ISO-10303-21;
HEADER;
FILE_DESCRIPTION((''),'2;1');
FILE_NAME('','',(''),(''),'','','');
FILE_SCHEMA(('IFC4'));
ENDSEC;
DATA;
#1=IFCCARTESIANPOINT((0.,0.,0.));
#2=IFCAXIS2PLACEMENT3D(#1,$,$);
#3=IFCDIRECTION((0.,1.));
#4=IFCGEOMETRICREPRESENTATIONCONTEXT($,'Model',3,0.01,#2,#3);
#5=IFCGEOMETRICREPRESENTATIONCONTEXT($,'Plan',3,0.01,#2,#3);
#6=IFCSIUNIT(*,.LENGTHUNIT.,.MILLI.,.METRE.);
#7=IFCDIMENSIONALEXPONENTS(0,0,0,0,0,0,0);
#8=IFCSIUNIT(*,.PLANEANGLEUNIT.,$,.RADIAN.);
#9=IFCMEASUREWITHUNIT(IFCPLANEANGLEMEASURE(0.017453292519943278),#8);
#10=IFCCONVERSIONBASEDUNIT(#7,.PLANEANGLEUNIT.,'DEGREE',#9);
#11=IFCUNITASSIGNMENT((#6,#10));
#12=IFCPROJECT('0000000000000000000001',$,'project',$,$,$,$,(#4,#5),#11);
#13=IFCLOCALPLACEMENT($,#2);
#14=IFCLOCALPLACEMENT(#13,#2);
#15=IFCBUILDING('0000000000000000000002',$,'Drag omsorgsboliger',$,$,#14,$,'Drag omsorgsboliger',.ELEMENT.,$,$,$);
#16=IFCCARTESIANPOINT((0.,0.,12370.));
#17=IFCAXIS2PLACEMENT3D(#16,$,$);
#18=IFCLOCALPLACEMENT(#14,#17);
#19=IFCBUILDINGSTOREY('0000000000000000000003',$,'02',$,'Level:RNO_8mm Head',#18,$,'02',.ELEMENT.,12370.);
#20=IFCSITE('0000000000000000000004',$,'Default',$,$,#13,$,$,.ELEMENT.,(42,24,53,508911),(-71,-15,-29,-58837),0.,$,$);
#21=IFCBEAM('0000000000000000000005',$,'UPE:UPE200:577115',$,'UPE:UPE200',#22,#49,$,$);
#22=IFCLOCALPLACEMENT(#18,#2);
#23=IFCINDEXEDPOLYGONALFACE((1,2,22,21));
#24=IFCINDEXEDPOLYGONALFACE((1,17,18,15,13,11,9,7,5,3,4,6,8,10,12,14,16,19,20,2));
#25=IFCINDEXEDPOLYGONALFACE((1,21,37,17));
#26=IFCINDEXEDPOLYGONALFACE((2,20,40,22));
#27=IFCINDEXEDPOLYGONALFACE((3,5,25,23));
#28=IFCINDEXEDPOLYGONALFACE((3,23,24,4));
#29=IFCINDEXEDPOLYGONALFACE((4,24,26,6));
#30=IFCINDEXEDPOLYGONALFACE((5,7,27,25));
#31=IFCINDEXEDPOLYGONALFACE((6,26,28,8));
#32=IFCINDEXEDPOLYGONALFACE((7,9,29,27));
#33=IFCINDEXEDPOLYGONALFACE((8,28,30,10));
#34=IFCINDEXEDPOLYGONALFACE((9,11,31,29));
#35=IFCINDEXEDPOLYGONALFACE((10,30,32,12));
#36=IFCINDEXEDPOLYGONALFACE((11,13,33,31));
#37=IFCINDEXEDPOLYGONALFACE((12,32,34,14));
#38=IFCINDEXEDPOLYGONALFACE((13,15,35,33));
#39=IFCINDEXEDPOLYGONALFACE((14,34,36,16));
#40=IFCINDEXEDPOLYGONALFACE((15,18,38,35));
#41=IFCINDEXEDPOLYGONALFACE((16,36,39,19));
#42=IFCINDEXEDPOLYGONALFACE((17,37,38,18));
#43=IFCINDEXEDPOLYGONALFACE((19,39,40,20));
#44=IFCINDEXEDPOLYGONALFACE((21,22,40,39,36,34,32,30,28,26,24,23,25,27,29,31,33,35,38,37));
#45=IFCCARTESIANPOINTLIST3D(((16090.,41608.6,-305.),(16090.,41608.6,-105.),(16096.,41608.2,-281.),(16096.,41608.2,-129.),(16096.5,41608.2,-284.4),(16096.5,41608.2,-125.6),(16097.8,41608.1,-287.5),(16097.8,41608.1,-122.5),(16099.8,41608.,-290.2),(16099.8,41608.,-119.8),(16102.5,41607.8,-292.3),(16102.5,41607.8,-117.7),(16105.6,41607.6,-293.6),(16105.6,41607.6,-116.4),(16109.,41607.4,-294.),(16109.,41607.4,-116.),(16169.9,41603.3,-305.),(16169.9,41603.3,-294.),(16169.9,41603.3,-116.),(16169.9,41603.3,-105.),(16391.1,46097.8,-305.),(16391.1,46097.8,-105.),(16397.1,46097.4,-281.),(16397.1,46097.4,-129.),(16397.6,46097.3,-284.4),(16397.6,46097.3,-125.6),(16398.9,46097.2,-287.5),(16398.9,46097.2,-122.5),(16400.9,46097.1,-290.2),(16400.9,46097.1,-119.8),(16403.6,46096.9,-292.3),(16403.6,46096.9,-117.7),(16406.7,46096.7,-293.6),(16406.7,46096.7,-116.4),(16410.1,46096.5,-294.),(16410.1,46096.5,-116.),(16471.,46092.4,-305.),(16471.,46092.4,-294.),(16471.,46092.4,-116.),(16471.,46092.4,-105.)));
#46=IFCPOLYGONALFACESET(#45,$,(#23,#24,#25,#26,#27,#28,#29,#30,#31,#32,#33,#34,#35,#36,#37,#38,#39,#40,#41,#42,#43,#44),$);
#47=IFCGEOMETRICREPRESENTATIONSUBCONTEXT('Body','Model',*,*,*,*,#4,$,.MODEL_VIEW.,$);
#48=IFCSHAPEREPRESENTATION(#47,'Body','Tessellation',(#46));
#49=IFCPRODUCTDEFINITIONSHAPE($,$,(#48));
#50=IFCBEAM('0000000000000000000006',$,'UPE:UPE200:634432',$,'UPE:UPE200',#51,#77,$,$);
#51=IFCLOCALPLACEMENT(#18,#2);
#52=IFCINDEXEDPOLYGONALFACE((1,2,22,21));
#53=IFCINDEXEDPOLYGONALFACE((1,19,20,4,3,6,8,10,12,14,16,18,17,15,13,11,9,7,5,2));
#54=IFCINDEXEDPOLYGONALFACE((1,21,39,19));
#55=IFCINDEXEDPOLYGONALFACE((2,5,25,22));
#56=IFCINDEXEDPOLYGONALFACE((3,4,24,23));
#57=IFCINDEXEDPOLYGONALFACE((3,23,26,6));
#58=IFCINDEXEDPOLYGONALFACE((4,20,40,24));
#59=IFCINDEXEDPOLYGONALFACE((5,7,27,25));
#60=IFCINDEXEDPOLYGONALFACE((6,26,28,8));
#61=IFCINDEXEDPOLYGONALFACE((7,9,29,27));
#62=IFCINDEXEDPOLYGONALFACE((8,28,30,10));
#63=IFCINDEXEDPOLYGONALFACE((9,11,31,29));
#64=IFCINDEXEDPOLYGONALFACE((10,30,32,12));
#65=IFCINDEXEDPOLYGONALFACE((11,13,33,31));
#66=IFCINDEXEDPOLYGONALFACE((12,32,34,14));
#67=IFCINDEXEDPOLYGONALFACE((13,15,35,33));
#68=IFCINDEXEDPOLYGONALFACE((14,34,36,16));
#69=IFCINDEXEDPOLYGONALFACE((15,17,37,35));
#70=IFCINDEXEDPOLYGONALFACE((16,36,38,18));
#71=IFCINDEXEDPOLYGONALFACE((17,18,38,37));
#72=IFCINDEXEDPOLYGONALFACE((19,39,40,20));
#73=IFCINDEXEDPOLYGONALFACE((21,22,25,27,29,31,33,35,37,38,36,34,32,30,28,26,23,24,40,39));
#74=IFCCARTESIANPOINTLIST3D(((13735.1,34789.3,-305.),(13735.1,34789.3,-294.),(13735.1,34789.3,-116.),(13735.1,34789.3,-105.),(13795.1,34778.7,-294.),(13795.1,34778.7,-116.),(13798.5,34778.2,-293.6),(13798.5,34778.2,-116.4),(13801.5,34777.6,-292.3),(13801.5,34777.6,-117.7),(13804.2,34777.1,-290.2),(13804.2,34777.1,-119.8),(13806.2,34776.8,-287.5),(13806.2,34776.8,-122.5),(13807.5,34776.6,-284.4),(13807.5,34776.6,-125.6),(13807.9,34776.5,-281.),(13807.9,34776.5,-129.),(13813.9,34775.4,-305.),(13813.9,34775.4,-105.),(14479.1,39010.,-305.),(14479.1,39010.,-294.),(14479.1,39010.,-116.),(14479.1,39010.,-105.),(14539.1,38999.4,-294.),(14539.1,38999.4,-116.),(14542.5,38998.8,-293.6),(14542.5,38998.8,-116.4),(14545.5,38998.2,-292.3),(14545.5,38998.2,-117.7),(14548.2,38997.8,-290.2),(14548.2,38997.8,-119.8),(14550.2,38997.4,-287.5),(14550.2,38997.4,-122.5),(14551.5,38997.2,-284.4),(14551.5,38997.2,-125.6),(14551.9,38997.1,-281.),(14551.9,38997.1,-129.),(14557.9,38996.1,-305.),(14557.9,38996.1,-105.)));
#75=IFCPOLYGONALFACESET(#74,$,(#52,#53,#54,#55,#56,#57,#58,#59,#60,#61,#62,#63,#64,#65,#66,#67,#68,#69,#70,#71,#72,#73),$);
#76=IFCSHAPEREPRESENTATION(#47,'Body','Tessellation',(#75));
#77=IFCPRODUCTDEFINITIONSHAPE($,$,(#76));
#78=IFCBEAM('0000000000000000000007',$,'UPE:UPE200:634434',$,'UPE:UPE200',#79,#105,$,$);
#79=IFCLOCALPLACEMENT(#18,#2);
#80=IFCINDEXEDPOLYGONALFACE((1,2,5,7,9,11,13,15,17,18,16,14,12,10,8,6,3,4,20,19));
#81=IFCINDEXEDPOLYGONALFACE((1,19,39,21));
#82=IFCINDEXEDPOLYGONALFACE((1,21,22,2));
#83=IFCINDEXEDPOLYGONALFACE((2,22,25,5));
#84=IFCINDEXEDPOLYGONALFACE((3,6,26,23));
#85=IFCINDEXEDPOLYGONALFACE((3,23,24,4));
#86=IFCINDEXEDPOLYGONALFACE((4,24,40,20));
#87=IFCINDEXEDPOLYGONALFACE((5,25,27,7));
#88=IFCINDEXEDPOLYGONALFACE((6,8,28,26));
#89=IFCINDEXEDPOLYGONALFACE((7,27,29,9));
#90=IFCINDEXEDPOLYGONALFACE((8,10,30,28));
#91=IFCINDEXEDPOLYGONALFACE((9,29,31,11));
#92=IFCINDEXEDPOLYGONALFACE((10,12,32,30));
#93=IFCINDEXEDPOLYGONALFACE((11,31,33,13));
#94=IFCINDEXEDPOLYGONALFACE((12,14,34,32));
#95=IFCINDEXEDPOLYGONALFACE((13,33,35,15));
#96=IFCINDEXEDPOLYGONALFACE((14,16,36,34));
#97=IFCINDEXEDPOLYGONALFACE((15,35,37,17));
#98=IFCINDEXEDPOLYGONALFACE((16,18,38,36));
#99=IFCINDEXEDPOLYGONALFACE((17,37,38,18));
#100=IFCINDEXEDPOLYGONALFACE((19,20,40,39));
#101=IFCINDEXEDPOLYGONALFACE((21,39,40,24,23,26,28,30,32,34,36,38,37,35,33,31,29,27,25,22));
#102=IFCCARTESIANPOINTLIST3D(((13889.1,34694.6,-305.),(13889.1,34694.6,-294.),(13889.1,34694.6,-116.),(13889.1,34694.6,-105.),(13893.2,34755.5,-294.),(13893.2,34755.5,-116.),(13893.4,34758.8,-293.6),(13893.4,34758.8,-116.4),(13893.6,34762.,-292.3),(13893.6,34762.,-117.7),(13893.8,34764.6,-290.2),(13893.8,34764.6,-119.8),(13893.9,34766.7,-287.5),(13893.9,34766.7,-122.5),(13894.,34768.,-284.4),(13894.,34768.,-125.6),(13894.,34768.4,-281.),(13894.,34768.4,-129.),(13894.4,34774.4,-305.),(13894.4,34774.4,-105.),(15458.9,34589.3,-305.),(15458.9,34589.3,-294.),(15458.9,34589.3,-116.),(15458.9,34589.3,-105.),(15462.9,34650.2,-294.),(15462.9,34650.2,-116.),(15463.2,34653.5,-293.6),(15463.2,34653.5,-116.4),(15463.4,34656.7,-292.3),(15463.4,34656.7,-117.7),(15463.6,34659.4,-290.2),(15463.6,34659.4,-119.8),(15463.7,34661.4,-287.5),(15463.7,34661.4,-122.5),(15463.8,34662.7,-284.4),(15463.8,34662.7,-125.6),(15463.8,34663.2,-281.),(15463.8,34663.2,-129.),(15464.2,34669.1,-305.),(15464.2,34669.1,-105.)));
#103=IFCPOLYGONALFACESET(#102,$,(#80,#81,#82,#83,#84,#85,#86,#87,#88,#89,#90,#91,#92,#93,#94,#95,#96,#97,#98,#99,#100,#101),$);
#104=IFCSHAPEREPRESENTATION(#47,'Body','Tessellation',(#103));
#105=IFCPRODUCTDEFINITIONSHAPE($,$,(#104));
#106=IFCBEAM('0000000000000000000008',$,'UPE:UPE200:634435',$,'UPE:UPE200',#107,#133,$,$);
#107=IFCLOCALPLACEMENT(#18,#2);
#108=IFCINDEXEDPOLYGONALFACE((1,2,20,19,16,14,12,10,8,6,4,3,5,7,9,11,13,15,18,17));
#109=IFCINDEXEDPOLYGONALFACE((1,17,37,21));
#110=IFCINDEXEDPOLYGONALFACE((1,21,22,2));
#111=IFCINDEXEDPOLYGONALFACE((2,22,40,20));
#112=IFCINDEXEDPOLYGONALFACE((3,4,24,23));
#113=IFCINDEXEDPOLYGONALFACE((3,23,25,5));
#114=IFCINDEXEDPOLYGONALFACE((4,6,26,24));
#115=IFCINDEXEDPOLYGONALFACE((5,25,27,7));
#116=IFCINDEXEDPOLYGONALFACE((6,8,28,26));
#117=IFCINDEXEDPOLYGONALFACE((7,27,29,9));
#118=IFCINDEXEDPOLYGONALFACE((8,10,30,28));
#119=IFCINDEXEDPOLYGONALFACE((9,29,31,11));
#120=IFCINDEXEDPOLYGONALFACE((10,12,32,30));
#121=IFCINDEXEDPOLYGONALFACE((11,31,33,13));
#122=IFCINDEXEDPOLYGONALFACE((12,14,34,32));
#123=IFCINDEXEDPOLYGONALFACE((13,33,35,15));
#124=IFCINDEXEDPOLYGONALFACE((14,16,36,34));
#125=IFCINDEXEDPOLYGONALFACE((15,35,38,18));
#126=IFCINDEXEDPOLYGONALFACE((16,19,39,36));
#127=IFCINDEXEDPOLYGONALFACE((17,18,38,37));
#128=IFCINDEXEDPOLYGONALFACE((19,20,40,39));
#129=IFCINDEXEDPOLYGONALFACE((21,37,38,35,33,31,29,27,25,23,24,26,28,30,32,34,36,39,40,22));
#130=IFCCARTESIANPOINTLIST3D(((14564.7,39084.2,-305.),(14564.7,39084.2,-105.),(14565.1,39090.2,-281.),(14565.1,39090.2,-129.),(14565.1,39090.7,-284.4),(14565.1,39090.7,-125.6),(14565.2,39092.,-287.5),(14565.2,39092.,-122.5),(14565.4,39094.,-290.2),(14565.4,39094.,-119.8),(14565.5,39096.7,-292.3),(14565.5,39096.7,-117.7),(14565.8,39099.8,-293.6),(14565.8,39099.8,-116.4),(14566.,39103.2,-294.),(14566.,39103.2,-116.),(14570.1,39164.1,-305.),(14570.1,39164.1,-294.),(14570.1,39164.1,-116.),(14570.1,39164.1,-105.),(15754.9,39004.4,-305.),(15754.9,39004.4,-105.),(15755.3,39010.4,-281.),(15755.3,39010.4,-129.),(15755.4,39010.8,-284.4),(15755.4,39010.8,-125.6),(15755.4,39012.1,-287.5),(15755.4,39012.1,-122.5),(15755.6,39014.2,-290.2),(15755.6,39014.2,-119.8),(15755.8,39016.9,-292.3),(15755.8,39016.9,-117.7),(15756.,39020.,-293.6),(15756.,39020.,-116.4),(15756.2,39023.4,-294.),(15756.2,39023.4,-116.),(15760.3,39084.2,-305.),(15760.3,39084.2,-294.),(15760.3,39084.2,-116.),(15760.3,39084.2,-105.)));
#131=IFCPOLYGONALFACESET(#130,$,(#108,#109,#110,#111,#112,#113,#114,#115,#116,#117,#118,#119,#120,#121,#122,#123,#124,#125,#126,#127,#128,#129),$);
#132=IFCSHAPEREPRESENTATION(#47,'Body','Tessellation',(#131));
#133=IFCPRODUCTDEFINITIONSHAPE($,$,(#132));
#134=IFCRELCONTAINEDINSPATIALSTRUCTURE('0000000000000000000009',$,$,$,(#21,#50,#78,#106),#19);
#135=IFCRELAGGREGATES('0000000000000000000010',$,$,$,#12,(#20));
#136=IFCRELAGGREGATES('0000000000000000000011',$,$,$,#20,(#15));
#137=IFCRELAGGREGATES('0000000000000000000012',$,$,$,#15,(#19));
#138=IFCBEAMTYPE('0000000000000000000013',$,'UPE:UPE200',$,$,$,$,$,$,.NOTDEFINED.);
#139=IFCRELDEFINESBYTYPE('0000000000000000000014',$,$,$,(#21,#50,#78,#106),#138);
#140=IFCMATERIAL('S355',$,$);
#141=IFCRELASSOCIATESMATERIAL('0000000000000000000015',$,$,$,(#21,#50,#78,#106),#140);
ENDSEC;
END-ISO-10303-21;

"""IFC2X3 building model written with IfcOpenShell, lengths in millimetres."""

from ifc_helpers import new_model, entity, si_unit, converted_unit, direction, frame, frame_2d, origin, place, context, subcontext, project, spatial, polyline, circle_curve, parameter, trimmed, segment, composite_curve, outline, extrude, material, type_object, element, save


model = new_model("IFC2X3")

# Units and contexts
model_context = context("Model", 3, precision=0.01, world=origin(), true_north=direction((0.0, 1.0)))
plan_context = context("Plan", 3, precision=0.01, world=origin(), true_north=direction((0.0, 1.0)))
body_context = subcontext(model_context, "Body", "Model", "MODEL_VIEW")
ifc_project = project(units=[si_unit("LENGTHUNIT", "METRE", prefix="MILLI"), converted_unit("PLANEANGLEUNIT", "DEGREE", entity("IfcPlaneAngleMeasure", 0.017453292519943278), si_unit("PLANEANGLEUNIT", "RADIAN"), dimensions=[0, 0, 0, 0, 0, 0, 0])], contexts=[model_context, plan_context])

# Site, building, storey
site_placement = place(None, origin())
site = spatial("IfcSite", under=ifc_project, at=site_placement, Name="Default", CompositionType="ELEMENT", RefLatitude=(42, 24, 53, 508911), RefLongitude=(-71, -15, -29, -58837), RefElevation=0.0)
building_placement = place(site_placement, origin())
building = spatial("IfcBuilding", under=site, at=building_placement, Name="Drag omsorgsboliger", LongName="Drag omsorgsboliger", CompositionType="ELEMENT")
storey_placement = place(building_placement, frame((0.0, 0.0, 12370.0)))
storey = spatial("IfcBuildingStorey", under=building, at=storey_placement, Name="02", ObjectType="Level:RNO_8mm Head", LongName="02", CompositionType="ELEMENT", Elevation=12370.0)

# Beams
ifc_material = material(Name="S355")
beam_type_1 = type_object("IfcBeamType", Name="UPE:UPE200", PredefinedType="NOTDEFINED")
beam_1_placement = place(storey_placement, frame((16115.8, 41610.5, -105.0), z_axis=(0.0, 0.0, 1.0), x_axis=(0.066923, 0.997758, 0.0)))
element("IfcBeam", 1, at=beam_1_placement, inside=storey, type_object=beam_type_1, material=ifc_material, Name="UPE:UPE200:577115", ObjectType="UPE:UPE200", context=body_context, shape_type="SweptSolid", body=[
    extrude(outline(composite_curve([segment(polyline([(-100.0, -43.0), (-89.0, -43.0)]), True, "CONTINUOUS"), segment(polyline([(-89.0, -43.0), (-89.0, 18.0)]), True, "CONTINUOUS"), segment(trimmed(circle_curve(frame_2d((-76.0, 18.0), x_axis=(-1.0, 0.0)), 13.0), [parameter(270.0)], [parameter(0.0)], True, "PARAMETER"), False, "CONTINUOUS"), segment(polyline([(-76.0, 31.0), (76.0, 31.0)]), True, "CONTINUOUS"), segment(trimmed(circle_curve(frame_2d((76.0, 18.0), x_axis=(0.0, 1.0)), 13.0), [parameter(270.0)], [parameter(0.0)], True, "PARAMETER"), False, "CONTINUOUS"), segment(polyline([(89.0, 18.0), (89.0, -43.0)]), True, "CONTINUOUS"), segment(polyline([(89.0, -43.0), (100.0, -43.0)]), True, "CONTINUOUS"), segment(polyline([(100.0, -43.0), (100.0, 37.0)]), True, "CONTINUOUS"), segment(polyline([(100.0, 37.0), (-100.0, 37.0)]), True, "CONTINUOUS"), segment(polyline([(-100.0, 37.0), (-100.0, -43.0)]), True, "CONTINUOUS")], self_intersect=False)), frame((-3.6, -11.4, -100.0), z_axis=(1.0, 0.0, 0.0), x_axis=(0.0, 0.0, -1.0)), (0.0, 0.0, 1.0), 4499.2),
])
beam_2_placement = place(storey_placement, frame((14547.5, 39084.8, -105.0), z_axis=(0.0, 0.0, 1.0), x_axis=(-0.173601, -0.984816, 0.0)))
element("IfcBeam", 2, at=beam_2_placement, inside=storey, type_object=beam_type_1, material=ifc_material, Name="UPE:UPE200:634432", ObjectType="UPE:UPE200", context=body_context, shape_type="SweptSolid", body=[
    extrude(outline(composite_curve([segment(polyline([(-100.0, -43.0), (-89.0, -43.0)]), True, "CONTINUOUS"), segment(polyline([(-89.0, -43.0), (-89.0, 18.0)]), True, "CONTINUOUS"), segment(trimmed(circle_curve(frame_2d((-76.0, 18.0), x_axis=(-1.0, 0.0)), 13.0), [parameter(270.0)], [parameter(0.0)], True, "PARAMETER"), False, "CONTINUOUS"), segment(polyline([(-76.0, 31.0), (76.0, 31.0)]), True, "CONTINUOUS"), segment(trimmed(circle_curve(frame_2d((76.0, 18.0), x_axis=(0.0, 1.0)), 13.0), [parameter(270.0)], [parameter(0.0)], True, "PARAMETER"), False, "CONTINUOUS"), segment(polyline([(89.0, 18.0), (89.0, -43.0)]), True, "CONTINUOUS"), segment(polyline([(89.0, -43.0), (100.0, -43.0)]), True, "CONTINUOUS"), segment(polyline([(100.0, -43.0), (100.0, 37.0)]), True, "CONTINUOUS"), segment(polyline([(100.0, 37.0), (-100.0, 37.0)]), True, "CONTINUOUS"), segment(polyline([(-100.0, 37.0), (-100.0, -43.0)]), True, "CONTINUOUS")], self_intersect=False)), frame((85.6, -11.4, -100.0), z_axis=(1.0, 0.0, 0.0), x_axis=(0.0, 0.0, -1.0)), (0.0, 0.0, 1.0), 4285.7),
])
beam_3_placement = place(storey_placement, frame((15462.5, 34643.6, -105.0), z_axis=(0.0, 0.0, 1.0), x_axis=(-0.997758, 0.066923, 0.0)))
element("IfcBeam", 3, at=beam_3_placement, inside=storey, type_object=beam_type_1, material=ifc_material, Name="UPE:UPE200:634434", ObjectType="UPE:UPE200", context=body_context, shape_type="SweptSolid", body=[
    extrude(outline(composite_curve([segment(polyline([(-100.0, -37.0), (100.0, -37.0)]), True, "CONTINUOUS"), segment(polyline([(100.0, -37.0), (100.0, 43.0)]), True, "CONTINUOUS"), segment(polyline([(100.0, 43.0), (89.0, 43.0)]), True, "CONTINUOUS"), segment(polyline([(89.0, 43.0), (89.0, -18.0)]), True, "CONTINUOUS"), segment(trimmed(circle_curve(frame_2d((76.0, -18.0), x_axis=(1.0, 0.0)), 13.0), [parameter(270.0)], [parameter(0.0)], True, "PARAMETER"), False, "CONTINUOUS"), segment(polyline([(76.0, -31.0), (-76.0, -31.0)]), True, "CONTINUOUS"), segment(trimmed(circle_curve(frame_2d((-76.0, -18.0), x_axis=(0.0, -1.0)), 13.0), [parameter(270.0)], [parameter(0.0)], True, "PARAMETER"), False, "CONTINUOUS"), segment(polyline([(-89.0, -18.0), (-89.0, 43.0)]), True, "CONTINUOUS"), segment(polyline([(-89.0, 43.0), (-100.0, 43.0)]), True, "CONTINUOUS"), segment(polyline([(-100.0, 43.0), (-100.0, -37.0)]), True, "CONTINUOUS")], self_intersect=False)), frame((0.0, 11.4, -100.0), z_axis=(1.0, 0.0, 0.0), x_axis=(0.0, 0.0, -1.0)), (0.0, 0.0, 1.0), 1573.3),
])
beam_4_placement = place(storey_placement, frame((15837.0, 39024.6, -105.0), z_axis=(0.0, 0.0, 1.0), x_axis=(-0.997758, 0.066923, 0.0)))
element("IfcBeam", 4, at=beam_4_placement, inside=storey, type_object=beam_type_1, material=ifc_material, Name="UPE:UPE200:634435", ObjectType="UPE:UPE200", context=body_context, shape_type="SweptSolid", body=[
    extrude(outline(composite_curve([segment(polyline([(-100.0, -43.0), (-89.0, -43.0)]), True, "CONTINUOUS"), segment(polyline([(-89.0, -43.0), (-89.0, 18.0)]), True, "CONTINUOUS"), segment(trimmed(circle_curve(frame_2d((-76.0, 18.0), x_axis=(-1.0, 0.0)), 13.0), [parameter(270.0)], [parameter(0.0)], True, "PARAMETER"), False, "CONTINUOUS"), segment(polyline([(-76.0, 31.0), (76.0, 31.0)]), True, "CONTINUOUS"), segment(trimmed(circle_curve(frame_2d((76.0, 18.0), x_axis=(0.0, 1.0)), 13.0), [parameter(270.0)], [parameter(0.0)], True, "PARAMETER"), False, "CONTINUOUS"), segment(polyline([(89.0, 18.0), (89.0, -43.0)]), True, "CONTINUOUS"), segment(polyline([(89.0, -43.0), (100.0, -43.0)]), True, "CONTINUOUS"), segment(polyline([(100.0, -43.0), (100.0, 37.0)]), True, "CONTINUOUS"), segment(polyline([(100.0, 37.0), (-100.0, 37.0)]), True, "CONTINUOUS"), segment(polyline([(-100.0, 37.0), (-100.0, -43.0)]), True, "CONTINUOUS")], self_intersect=False)), frame((80.5, -11.4, -100.0), z_axis=(1.0, 0.0, 0.0), x_axis=(0.0, 0.0, -1.0)), (0.0, 0.0, 1.0), 1192.9),
])

save(model, "model.ifc")
